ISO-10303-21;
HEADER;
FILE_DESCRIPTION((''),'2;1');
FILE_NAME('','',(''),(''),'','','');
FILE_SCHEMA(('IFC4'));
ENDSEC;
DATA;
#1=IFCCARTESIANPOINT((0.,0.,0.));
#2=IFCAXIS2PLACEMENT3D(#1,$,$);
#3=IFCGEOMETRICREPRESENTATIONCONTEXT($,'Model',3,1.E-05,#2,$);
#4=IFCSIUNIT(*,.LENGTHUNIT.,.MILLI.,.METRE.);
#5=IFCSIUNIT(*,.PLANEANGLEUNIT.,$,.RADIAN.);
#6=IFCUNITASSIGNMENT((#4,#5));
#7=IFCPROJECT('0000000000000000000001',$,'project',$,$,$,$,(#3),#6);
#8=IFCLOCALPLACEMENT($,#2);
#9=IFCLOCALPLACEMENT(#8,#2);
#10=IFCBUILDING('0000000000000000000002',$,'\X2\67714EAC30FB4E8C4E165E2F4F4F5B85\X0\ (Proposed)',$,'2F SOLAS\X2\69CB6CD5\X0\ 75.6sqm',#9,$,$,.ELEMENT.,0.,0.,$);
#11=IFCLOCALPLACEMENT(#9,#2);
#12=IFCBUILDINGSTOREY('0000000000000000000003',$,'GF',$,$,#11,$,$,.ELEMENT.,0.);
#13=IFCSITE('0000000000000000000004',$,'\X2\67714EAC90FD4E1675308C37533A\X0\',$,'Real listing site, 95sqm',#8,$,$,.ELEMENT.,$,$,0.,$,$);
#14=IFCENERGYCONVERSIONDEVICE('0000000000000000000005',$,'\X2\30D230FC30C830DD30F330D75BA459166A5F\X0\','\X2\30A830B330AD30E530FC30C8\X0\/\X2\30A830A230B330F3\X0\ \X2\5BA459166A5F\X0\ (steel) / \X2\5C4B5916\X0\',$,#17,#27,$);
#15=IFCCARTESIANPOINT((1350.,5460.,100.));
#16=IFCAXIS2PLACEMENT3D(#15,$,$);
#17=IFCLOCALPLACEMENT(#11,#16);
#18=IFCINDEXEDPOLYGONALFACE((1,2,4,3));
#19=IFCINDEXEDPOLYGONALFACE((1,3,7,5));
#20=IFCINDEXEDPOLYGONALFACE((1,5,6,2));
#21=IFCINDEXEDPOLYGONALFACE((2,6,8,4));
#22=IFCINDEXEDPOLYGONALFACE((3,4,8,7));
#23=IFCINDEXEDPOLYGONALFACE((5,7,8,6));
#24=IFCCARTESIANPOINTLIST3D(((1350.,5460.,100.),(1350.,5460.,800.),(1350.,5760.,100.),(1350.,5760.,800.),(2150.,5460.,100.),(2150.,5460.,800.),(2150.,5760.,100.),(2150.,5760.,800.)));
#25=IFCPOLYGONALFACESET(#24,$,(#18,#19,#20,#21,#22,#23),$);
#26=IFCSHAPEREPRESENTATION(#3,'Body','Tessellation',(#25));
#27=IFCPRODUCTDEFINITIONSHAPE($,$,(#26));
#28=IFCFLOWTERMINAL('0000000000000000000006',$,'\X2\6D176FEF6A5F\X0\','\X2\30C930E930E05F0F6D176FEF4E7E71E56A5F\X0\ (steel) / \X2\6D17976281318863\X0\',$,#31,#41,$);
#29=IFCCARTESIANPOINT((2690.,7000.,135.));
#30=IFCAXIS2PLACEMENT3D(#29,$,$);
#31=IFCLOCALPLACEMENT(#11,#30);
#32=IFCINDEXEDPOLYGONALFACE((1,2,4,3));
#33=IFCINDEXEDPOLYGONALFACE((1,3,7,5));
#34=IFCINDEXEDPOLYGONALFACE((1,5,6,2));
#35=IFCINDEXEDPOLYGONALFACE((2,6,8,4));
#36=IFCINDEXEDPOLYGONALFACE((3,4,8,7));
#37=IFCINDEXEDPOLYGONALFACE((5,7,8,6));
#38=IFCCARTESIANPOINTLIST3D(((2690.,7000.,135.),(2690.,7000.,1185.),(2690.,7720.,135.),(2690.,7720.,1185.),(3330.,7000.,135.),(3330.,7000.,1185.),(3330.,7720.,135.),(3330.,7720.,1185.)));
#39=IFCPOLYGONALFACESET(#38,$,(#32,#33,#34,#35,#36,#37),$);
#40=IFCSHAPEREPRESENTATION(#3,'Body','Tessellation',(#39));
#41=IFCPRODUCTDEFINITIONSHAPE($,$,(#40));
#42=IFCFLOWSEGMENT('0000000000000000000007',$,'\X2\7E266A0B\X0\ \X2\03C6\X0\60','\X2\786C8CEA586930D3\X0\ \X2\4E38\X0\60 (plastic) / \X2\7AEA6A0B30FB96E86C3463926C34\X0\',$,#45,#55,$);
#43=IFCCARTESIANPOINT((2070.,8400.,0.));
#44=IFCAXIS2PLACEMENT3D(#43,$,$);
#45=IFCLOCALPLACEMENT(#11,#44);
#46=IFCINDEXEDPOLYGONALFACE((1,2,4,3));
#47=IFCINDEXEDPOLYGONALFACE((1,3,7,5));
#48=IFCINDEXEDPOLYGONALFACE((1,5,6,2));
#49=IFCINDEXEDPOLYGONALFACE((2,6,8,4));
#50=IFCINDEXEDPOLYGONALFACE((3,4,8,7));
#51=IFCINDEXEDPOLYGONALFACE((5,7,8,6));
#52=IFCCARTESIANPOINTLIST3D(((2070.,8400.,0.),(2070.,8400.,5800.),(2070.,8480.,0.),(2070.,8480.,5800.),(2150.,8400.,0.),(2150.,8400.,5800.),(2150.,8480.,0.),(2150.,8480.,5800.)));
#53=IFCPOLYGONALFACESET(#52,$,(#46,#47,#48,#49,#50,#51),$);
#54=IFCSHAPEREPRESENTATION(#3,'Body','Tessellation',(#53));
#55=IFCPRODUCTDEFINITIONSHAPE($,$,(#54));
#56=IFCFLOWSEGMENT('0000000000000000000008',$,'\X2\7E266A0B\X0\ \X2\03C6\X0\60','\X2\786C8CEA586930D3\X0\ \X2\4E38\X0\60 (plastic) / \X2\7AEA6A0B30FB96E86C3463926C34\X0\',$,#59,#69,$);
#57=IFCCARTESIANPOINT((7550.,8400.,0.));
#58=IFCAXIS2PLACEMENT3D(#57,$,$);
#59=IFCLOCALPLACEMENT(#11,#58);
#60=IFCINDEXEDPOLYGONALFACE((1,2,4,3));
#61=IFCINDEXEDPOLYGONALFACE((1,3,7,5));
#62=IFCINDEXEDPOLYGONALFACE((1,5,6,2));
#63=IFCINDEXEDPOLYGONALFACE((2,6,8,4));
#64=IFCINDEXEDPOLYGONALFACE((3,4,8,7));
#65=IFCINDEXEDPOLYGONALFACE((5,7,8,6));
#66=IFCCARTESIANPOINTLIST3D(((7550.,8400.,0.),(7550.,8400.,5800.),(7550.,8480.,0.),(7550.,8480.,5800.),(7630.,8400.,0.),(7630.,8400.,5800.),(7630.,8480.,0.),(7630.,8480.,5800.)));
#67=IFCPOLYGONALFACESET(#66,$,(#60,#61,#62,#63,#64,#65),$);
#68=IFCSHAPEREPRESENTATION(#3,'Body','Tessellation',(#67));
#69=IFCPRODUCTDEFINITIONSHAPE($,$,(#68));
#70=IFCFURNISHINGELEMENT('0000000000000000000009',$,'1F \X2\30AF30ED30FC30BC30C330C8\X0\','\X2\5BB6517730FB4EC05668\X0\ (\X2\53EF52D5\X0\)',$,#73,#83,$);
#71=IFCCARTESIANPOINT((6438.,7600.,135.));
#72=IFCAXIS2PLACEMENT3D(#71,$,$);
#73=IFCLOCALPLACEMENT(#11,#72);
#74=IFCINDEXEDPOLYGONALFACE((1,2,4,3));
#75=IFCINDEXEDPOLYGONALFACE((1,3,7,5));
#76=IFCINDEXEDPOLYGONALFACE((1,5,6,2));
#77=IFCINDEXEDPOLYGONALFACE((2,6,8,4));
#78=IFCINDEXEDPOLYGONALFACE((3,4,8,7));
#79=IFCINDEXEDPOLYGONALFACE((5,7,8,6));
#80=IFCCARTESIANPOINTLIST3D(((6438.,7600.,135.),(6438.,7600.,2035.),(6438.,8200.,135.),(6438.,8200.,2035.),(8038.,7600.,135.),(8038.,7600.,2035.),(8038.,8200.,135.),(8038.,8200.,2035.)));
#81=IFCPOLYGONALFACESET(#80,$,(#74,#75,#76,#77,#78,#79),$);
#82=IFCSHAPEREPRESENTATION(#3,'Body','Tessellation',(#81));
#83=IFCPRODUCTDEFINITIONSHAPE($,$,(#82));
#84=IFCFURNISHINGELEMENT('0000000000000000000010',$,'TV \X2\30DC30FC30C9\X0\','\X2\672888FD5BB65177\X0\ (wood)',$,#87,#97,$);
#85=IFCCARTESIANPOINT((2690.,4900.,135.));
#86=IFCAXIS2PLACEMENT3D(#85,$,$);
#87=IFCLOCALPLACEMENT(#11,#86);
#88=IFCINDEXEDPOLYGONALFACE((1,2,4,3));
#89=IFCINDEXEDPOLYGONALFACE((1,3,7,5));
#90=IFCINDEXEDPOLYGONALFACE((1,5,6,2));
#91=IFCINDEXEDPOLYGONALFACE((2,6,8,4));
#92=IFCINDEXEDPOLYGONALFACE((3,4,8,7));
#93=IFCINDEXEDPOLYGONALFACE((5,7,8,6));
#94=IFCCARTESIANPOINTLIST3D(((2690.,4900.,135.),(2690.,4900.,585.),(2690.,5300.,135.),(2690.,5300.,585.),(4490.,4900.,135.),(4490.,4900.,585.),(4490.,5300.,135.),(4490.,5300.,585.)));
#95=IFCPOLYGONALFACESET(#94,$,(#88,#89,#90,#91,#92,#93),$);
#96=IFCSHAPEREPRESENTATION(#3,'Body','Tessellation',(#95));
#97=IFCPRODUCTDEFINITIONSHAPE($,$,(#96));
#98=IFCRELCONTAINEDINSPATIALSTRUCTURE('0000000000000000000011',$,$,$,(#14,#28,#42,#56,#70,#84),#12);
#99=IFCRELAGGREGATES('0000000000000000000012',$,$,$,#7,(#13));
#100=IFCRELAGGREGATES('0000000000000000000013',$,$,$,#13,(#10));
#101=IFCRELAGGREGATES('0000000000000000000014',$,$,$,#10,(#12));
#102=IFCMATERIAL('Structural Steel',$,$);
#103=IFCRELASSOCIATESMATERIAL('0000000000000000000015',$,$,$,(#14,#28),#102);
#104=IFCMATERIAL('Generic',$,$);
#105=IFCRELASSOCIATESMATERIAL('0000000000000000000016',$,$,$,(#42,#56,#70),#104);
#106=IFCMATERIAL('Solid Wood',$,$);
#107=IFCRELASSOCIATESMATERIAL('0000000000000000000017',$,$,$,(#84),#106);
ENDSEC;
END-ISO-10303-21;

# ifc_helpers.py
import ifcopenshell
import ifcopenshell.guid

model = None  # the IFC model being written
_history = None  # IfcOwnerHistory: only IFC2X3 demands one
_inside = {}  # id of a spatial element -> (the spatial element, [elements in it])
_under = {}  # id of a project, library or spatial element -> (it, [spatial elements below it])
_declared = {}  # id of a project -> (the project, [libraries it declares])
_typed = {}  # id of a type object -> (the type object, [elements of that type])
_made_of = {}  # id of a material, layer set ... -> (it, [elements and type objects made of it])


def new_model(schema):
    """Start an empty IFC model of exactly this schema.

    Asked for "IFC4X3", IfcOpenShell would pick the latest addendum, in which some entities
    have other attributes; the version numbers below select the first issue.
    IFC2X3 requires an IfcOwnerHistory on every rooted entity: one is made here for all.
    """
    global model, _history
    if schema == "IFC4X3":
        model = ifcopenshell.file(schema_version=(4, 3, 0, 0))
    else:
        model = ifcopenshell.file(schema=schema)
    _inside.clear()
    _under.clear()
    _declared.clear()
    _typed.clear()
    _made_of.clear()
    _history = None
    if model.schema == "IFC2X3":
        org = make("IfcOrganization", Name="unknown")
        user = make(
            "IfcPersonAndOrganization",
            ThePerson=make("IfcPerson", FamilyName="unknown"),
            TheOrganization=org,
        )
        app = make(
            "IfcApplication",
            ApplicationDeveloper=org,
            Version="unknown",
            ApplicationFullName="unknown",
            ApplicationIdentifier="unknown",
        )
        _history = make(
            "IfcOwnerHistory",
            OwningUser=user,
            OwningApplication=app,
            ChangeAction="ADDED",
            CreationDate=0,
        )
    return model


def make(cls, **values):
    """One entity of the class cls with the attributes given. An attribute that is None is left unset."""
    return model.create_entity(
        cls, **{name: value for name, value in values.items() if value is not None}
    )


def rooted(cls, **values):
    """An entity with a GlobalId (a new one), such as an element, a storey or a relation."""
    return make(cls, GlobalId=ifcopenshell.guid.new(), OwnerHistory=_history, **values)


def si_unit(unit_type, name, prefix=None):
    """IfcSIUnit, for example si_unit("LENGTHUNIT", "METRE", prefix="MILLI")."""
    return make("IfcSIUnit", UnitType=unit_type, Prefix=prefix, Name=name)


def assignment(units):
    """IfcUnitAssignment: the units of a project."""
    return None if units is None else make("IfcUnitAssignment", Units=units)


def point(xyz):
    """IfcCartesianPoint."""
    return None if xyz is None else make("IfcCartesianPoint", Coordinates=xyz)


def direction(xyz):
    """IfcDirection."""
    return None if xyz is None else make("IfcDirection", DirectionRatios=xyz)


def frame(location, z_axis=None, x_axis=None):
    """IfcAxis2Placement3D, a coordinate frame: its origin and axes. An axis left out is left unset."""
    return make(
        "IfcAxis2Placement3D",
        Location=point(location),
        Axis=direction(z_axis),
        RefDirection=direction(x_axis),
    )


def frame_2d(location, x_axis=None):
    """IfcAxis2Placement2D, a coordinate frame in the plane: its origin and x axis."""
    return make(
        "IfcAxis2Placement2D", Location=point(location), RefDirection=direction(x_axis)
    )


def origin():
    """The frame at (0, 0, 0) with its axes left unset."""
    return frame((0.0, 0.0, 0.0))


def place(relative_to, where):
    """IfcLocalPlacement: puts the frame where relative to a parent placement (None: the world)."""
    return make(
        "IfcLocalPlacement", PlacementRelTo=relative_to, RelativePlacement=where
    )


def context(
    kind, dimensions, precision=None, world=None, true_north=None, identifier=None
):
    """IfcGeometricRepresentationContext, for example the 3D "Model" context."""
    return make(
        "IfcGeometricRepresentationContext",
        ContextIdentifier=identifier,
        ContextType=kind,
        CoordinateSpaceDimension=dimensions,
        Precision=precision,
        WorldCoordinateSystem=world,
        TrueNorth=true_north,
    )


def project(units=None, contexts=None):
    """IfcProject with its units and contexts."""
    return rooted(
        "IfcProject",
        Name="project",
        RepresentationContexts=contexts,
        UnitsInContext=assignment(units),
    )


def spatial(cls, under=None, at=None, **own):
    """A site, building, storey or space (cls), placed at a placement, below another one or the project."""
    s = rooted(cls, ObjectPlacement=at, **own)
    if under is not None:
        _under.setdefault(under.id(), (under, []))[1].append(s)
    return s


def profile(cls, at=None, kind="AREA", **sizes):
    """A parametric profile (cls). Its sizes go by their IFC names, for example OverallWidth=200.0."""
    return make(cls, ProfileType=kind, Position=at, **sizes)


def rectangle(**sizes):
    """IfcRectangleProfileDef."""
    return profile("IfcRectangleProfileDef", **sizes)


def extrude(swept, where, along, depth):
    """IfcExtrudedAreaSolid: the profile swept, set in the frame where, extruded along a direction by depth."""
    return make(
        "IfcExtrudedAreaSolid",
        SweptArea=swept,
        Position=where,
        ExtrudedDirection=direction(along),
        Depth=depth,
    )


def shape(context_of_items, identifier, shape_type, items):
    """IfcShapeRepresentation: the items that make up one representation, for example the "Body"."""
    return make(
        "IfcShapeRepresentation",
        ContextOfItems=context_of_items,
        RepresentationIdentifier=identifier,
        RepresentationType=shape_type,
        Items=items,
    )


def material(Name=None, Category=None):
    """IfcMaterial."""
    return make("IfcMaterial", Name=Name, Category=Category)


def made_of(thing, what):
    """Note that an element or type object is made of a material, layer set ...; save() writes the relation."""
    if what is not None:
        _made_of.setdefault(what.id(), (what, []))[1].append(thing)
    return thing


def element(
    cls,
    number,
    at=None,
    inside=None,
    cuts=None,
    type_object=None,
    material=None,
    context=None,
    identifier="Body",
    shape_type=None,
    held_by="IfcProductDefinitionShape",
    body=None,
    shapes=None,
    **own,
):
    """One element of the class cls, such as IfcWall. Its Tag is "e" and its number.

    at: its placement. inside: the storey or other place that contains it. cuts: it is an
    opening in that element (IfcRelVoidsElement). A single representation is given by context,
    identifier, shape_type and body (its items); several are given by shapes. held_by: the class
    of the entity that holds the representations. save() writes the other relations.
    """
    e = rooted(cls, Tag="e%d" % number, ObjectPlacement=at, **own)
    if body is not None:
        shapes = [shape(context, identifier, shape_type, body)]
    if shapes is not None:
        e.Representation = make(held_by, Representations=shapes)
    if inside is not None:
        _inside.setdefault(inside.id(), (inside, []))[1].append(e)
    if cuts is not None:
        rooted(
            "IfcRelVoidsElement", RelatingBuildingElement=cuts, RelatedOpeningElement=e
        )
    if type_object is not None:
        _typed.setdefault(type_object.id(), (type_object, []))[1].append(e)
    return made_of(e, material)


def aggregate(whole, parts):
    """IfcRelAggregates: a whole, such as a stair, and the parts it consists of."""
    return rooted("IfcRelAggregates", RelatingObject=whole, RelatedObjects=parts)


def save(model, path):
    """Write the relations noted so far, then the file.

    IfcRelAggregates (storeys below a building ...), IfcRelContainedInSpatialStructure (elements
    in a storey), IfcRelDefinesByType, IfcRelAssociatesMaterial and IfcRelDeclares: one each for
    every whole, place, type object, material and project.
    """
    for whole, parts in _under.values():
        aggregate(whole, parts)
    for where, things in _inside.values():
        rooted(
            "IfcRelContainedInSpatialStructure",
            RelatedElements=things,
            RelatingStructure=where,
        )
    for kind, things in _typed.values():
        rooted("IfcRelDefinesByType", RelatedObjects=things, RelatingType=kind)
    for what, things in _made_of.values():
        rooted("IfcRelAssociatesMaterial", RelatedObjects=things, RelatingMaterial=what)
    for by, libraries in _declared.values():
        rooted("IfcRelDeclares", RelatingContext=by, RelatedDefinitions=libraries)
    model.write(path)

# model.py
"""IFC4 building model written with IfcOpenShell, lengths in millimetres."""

from ifc_helpers import new_model, si_unit, frame, frame_2d, origin, place, context, project, spatial, rectangle, extrude, material, element, save


model = new_model("IFC4")

# Units and contexts
model_context = context("Model", 3, precision=1e-05, world=origin())
ifc_project = project(units=[si_unit("LENGTHUNIT", "METRE", prefix="MILLI"), si_unit("PLANEANGLEUNIT", "RADIAN")], contexts=[model_context])

# Site, building, storey
site_placement = place(None, origin())
site = spatial("IfcSite", under=ifc_project, at=site_placement, Name="東京都世田谷区", ObjectType="Real listing site, 95sqm", CompositionType="ELEMENT", RefElevation=0.0)
building_placement = place(site_placement, origin())
building = spatial("IfcBuilding", under=site, at=building_placement, Name="東京・二世帯住宅 (Proposed)", ObjectType="2F SOLAS構法 75.6sqm", CompositionType="ELEMENT", ElevationOfRefHeight=0.0, ElevationOfTerrain=0.0)
storey_placement = place(building_placement, origin())
storey = spatial("IfcBuildingStorey", under=building, at=storey_placement, Name="GF", CompositionType="ELEMENT", Elevation=0.0)

# Shared definitions
ifc_material_1 = material(Name="Solid Wood")

# Shared definitions
ifc_material_2 = material(Name="Generic")

# Shared definitions
ifc_material_3 = material(Name="Structural Steel")

# Energy conversion device
energy_conversion_device_placement = place(storey_placement, frame((1350.0, 5460.0, 100.0)))
element("IfcEnergyConversionDevice", 1, at=energy_conversion_device_placement, inside=storey, material=ifc_material_3, Name="ヒートポンプ室外機", Description="エコキュート/エアコン 室外機 (steel) / 屋外", context=model_context, shape_type="SweptSolid", body=[
    extrude(rectangle(XDim=800.0, YDim=300.0, at=frame_2d((400.0, 150.0))), frame((1350.0, 5460.0, 100.0)), (0.0, 0.0, 1.0), 700.0),
])

# Flow terminal
flow_terminal_placement = place(storey_placement, frame((2690.0, 7000.0, 135.0)))
element("IfcFlowTerminal", 2, at=flow_terminal_placement, inside=storey, material=ifc_material_3, Name="洗濯機", Description="ドラム式洗濯乾燥機 (steel) / 洗面脱衣", context=model_context, shape_type="SweptSolid", body=[
    extrude(rectangle(XDim=640.0, YDim=720.0, at=frame_2d((320.0, 360.0))), frame((2690.0, 7000.0, 135.0)), (0.0, 0.0, 1.0), 1050.0),
])

# Flow segments
flow_segment_1_placement = place(storey_placement, frame((2070.0, 8400.0, 0.0)))
element("IfcFlowSegment", 3, at=flow_segment_1_placement, inside=storey, material=ifc_material_2, Name="縦樋 φ60", Description="硬質塩ビ 丸60 (plastic) / 竪樋・雨水排水", context=model_context, shape_type="SweptSolid", body=[
    extrude(rectangle(XDim=80.0, YDim=80.0, at=frame_2d((40.0, 40.0))), frame((2070.0, 8400.0, 0.0)), (0.0, 0.0, 1.0), 5800.0),
])
flow_segment_2_placement = place(storey_placement, frame((7550.0, 8400.0, 0.0)))
element("IfcFlowSegment", 4, at=flow_segment_2_placement, inside=storey, material=ifc_material_2, Name="縦樋 φ60", Description="硬質塩ビ 丸60 (plastic) / 竪樋・雨水排水", context=model_context, shape_type="SweptSolid", body=[
    extrude(rectangle(XDim=80.0, YDim=80.0, at=frame_2d((40.0, 40.0))), frame((7550.0, 8400.0, 0.0)), (0.0, 0.0, 1.0), 5800.0),
])

# Furnishing elements
furnishing_1_placement = place(storey_placement, frame((6438.0, 7600.0, 135.0)))
element("IfcFurnishingElement", 5, at=furnishing_1_placement, inside=storey, material=ifc_material_2, Name="1F クローゼット", Description="家具・什器 (可動)", context=model_context, shape_type="SweptSolid", body=[
    extrude(rectangle(XDim=1600.0, YDim=600.0, at=frame_2d((800.0, 300.0))), frame((6438.0, 7600.0, 135.0)), (0.0, 0.0, 1.0), 1900.0),
])
furnishing_2_placement = place(storey_placement, frame((2690.0, 4900.0, 135.0)))
element("IfcFurnishingElement", 6, at=furnishing_2_placement, inside=storey, material=ifc_material_1, Name="TV ボード", Description="木製家具 (wood)", context=model_context, shape_type="SweptSolid", body=[
    extrude(rectangle(XDim=1800.0, YDim=400.0, at=frame_2d((900.0, 200.0))), frame((2690.0, 4900.0, 135.0)), (0.0, 0.0, 1.0), 450.0),
])

save(model, "model.ifc")
